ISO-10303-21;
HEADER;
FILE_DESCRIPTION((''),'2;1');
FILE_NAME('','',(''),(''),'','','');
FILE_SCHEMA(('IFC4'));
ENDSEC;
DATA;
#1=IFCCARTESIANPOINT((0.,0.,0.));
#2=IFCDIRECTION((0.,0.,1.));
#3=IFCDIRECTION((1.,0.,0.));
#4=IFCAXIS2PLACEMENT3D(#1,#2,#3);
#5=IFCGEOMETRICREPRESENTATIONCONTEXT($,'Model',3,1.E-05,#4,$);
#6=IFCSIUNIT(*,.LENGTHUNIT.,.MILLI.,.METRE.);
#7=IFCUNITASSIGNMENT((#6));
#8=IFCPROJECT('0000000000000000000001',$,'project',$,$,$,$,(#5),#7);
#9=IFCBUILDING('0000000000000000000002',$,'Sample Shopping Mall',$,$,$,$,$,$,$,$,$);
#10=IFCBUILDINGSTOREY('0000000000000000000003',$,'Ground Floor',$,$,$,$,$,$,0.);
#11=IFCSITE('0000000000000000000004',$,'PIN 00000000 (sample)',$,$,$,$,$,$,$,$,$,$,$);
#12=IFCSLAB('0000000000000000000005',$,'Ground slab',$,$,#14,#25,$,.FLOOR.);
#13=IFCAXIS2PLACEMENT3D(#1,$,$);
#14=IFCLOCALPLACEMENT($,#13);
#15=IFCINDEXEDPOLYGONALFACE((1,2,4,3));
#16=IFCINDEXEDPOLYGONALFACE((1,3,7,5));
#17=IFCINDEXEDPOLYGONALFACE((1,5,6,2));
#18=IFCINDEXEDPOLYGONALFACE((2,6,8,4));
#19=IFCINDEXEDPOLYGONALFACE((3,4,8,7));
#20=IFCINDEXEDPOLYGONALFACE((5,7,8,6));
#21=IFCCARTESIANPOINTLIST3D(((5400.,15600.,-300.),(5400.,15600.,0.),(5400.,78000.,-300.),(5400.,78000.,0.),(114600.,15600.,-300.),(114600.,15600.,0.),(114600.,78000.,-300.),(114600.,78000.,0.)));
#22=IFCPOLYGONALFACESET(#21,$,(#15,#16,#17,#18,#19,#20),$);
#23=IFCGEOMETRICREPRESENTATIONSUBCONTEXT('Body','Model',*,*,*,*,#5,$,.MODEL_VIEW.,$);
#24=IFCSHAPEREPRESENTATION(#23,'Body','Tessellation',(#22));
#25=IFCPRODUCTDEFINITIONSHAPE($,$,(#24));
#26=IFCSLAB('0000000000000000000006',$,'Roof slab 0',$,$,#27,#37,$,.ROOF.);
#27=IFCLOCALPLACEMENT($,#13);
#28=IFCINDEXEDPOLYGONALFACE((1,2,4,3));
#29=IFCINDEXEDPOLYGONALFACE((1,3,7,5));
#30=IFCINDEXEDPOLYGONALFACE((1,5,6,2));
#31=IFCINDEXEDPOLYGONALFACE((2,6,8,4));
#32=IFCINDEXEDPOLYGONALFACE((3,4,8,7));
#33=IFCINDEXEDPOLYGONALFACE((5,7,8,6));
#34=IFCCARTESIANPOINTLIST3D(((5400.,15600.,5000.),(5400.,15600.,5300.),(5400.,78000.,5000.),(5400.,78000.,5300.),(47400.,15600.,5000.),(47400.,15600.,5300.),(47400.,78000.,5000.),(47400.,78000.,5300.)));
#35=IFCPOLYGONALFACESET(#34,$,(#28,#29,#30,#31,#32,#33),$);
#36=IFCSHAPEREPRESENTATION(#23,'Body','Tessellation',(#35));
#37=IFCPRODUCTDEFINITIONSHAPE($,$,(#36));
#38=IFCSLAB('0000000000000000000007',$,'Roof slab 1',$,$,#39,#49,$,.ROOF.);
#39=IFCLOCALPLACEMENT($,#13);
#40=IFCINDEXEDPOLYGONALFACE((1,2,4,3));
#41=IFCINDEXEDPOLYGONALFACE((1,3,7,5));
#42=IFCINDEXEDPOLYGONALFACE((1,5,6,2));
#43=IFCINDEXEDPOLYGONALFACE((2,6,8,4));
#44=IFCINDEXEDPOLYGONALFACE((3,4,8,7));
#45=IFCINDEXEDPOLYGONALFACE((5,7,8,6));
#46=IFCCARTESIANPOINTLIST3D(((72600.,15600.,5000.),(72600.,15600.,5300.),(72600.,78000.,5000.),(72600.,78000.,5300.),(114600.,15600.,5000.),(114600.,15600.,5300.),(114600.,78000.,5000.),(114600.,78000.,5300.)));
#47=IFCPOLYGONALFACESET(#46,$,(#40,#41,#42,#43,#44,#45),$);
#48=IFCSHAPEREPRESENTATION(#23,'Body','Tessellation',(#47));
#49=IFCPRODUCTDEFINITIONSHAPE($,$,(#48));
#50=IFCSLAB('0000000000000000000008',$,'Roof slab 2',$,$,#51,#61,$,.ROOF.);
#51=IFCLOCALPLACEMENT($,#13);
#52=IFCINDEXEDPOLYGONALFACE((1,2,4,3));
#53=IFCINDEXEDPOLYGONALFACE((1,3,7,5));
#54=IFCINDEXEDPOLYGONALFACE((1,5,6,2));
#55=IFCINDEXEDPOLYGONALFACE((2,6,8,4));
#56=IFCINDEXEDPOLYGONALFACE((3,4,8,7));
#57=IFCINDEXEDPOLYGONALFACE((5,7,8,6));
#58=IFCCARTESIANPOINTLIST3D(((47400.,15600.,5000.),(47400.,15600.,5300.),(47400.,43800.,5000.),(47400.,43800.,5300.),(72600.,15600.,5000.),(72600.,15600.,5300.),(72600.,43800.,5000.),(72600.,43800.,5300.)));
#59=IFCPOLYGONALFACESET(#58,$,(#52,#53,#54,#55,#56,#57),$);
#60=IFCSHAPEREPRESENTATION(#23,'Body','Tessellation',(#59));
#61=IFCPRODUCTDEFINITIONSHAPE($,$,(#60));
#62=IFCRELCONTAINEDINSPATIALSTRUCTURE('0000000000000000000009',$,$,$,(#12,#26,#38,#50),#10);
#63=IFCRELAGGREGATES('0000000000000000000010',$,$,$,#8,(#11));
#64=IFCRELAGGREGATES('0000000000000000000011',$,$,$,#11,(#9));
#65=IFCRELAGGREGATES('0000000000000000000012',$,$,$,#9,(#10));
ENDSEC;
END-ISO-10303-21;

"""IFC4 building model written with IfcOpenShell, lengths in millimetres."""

from ifc_helpers import new_model, si_unit, frame, origin_with_axes, place, context, subcontext, project, spatial, indexed_curve, outline, extrude, element, save


model = new_model("IFC4")

# Units and contexts
model_context = context("Model", 3, precision=1e-05, world=origin_with_axes())
body_context = subcontext(model_context, "Body", "Model", "MODEL_VIEW")
ifc_project = project(units=[si_unit("LENGTHUNIT", "METRE", prefix="MILLI")], contexts=[model_context])

# Site, building, storey
site = spatial("IfcSite", under=ifc_project, Name="PIN 00000000 (sample)")
building = spatial("IfcBuilding", under=site, Name="Sample Shopping Mall")
storey = spatial("IfcBuildingStorey", under=building, Name="Ground Floor", Elevation=0.0)

# Slabs
slab_1_placement = place(None, frame((0.0, 0.0, -300.0), z_axis=(0.0, 0.0, 1.0), x_axis=(1.0, 0.0, 0.0)))
element("IfcSlab", 1, at=slab_1_placement, inside=storey, Name="Ground slab", PredefinedType="FLOOR", context=body_context, shape_type="SweptSolid", body=[
    extrude(outline(indexed_curve([(5400.0, 15600.0), (114600.0, 15600.0), (114600.0, 78000.0), (5400.0, 78000.0)])), None, (0.0, 0.0, 1.0), 300.0),
])
slab_2_placement = place(None, frame((0.0, 0.0, 5000.0), z_axis=(0.0, 0.0, 1.0), x_axis=(1.0, 0.0, 0.0)))
element("IfcSlab", 2, at=slab_2_placement, inside=storey, Name="Roof slab 0", PredefinedType="ROOF", context=body_context, shape_type="SweptSolid", body=[
    extrude(outline(indexed_curve([(5400.0, 15600.0), (47400.0, 15600.0), (47400.0, 78000.0), (5400.0, 78000.0)])), None, (0.0, 0.0, 1.0), 300.0),
])
slab_3_placement = place(None, frame((0.0, 0.0, 5000.0), z_axis=(0.0, 0.0, 1.0), x_axis=(1.0, 0.0, 0.0)))
element("IfcSlab", 3, at=slab_3_placement, inside=storey, Name="Roof slab 1", PredefinedType="ROOF", context=body_context, shape_type="SweptSolid", body=[
    extrude(outline(indexed_curve([(72600.0, 15600.0), (114600.0, 15600.0), (114600.0, 78000.0), (72600.0, 78000.0)])), None, (0.0, 0.0, 1.0), 300.0),
])
slab_4_placement = place(None, frame((0.0, 0.0, 5000.0), z_axis=(0.0, 0.0, 1.0), x_axis=(1.0, 0.0, 0.0)))
element("IfcSlab", 4, at=slab_4_placement, inside=storey, Name="Roof slab 2", PredefinedType="ROOF", context=body_context, shape_type="SweptSolid", body=[
    extrude(outline(indexed_curve([(47400.0, 15600.0), (72600.0, 15600.0), (72600.0, 43800.0), (47400.0, 43800.0)])), None, (0.0, 0.0, 1.0), 300.0),
])

save(model, "model.ifc")
